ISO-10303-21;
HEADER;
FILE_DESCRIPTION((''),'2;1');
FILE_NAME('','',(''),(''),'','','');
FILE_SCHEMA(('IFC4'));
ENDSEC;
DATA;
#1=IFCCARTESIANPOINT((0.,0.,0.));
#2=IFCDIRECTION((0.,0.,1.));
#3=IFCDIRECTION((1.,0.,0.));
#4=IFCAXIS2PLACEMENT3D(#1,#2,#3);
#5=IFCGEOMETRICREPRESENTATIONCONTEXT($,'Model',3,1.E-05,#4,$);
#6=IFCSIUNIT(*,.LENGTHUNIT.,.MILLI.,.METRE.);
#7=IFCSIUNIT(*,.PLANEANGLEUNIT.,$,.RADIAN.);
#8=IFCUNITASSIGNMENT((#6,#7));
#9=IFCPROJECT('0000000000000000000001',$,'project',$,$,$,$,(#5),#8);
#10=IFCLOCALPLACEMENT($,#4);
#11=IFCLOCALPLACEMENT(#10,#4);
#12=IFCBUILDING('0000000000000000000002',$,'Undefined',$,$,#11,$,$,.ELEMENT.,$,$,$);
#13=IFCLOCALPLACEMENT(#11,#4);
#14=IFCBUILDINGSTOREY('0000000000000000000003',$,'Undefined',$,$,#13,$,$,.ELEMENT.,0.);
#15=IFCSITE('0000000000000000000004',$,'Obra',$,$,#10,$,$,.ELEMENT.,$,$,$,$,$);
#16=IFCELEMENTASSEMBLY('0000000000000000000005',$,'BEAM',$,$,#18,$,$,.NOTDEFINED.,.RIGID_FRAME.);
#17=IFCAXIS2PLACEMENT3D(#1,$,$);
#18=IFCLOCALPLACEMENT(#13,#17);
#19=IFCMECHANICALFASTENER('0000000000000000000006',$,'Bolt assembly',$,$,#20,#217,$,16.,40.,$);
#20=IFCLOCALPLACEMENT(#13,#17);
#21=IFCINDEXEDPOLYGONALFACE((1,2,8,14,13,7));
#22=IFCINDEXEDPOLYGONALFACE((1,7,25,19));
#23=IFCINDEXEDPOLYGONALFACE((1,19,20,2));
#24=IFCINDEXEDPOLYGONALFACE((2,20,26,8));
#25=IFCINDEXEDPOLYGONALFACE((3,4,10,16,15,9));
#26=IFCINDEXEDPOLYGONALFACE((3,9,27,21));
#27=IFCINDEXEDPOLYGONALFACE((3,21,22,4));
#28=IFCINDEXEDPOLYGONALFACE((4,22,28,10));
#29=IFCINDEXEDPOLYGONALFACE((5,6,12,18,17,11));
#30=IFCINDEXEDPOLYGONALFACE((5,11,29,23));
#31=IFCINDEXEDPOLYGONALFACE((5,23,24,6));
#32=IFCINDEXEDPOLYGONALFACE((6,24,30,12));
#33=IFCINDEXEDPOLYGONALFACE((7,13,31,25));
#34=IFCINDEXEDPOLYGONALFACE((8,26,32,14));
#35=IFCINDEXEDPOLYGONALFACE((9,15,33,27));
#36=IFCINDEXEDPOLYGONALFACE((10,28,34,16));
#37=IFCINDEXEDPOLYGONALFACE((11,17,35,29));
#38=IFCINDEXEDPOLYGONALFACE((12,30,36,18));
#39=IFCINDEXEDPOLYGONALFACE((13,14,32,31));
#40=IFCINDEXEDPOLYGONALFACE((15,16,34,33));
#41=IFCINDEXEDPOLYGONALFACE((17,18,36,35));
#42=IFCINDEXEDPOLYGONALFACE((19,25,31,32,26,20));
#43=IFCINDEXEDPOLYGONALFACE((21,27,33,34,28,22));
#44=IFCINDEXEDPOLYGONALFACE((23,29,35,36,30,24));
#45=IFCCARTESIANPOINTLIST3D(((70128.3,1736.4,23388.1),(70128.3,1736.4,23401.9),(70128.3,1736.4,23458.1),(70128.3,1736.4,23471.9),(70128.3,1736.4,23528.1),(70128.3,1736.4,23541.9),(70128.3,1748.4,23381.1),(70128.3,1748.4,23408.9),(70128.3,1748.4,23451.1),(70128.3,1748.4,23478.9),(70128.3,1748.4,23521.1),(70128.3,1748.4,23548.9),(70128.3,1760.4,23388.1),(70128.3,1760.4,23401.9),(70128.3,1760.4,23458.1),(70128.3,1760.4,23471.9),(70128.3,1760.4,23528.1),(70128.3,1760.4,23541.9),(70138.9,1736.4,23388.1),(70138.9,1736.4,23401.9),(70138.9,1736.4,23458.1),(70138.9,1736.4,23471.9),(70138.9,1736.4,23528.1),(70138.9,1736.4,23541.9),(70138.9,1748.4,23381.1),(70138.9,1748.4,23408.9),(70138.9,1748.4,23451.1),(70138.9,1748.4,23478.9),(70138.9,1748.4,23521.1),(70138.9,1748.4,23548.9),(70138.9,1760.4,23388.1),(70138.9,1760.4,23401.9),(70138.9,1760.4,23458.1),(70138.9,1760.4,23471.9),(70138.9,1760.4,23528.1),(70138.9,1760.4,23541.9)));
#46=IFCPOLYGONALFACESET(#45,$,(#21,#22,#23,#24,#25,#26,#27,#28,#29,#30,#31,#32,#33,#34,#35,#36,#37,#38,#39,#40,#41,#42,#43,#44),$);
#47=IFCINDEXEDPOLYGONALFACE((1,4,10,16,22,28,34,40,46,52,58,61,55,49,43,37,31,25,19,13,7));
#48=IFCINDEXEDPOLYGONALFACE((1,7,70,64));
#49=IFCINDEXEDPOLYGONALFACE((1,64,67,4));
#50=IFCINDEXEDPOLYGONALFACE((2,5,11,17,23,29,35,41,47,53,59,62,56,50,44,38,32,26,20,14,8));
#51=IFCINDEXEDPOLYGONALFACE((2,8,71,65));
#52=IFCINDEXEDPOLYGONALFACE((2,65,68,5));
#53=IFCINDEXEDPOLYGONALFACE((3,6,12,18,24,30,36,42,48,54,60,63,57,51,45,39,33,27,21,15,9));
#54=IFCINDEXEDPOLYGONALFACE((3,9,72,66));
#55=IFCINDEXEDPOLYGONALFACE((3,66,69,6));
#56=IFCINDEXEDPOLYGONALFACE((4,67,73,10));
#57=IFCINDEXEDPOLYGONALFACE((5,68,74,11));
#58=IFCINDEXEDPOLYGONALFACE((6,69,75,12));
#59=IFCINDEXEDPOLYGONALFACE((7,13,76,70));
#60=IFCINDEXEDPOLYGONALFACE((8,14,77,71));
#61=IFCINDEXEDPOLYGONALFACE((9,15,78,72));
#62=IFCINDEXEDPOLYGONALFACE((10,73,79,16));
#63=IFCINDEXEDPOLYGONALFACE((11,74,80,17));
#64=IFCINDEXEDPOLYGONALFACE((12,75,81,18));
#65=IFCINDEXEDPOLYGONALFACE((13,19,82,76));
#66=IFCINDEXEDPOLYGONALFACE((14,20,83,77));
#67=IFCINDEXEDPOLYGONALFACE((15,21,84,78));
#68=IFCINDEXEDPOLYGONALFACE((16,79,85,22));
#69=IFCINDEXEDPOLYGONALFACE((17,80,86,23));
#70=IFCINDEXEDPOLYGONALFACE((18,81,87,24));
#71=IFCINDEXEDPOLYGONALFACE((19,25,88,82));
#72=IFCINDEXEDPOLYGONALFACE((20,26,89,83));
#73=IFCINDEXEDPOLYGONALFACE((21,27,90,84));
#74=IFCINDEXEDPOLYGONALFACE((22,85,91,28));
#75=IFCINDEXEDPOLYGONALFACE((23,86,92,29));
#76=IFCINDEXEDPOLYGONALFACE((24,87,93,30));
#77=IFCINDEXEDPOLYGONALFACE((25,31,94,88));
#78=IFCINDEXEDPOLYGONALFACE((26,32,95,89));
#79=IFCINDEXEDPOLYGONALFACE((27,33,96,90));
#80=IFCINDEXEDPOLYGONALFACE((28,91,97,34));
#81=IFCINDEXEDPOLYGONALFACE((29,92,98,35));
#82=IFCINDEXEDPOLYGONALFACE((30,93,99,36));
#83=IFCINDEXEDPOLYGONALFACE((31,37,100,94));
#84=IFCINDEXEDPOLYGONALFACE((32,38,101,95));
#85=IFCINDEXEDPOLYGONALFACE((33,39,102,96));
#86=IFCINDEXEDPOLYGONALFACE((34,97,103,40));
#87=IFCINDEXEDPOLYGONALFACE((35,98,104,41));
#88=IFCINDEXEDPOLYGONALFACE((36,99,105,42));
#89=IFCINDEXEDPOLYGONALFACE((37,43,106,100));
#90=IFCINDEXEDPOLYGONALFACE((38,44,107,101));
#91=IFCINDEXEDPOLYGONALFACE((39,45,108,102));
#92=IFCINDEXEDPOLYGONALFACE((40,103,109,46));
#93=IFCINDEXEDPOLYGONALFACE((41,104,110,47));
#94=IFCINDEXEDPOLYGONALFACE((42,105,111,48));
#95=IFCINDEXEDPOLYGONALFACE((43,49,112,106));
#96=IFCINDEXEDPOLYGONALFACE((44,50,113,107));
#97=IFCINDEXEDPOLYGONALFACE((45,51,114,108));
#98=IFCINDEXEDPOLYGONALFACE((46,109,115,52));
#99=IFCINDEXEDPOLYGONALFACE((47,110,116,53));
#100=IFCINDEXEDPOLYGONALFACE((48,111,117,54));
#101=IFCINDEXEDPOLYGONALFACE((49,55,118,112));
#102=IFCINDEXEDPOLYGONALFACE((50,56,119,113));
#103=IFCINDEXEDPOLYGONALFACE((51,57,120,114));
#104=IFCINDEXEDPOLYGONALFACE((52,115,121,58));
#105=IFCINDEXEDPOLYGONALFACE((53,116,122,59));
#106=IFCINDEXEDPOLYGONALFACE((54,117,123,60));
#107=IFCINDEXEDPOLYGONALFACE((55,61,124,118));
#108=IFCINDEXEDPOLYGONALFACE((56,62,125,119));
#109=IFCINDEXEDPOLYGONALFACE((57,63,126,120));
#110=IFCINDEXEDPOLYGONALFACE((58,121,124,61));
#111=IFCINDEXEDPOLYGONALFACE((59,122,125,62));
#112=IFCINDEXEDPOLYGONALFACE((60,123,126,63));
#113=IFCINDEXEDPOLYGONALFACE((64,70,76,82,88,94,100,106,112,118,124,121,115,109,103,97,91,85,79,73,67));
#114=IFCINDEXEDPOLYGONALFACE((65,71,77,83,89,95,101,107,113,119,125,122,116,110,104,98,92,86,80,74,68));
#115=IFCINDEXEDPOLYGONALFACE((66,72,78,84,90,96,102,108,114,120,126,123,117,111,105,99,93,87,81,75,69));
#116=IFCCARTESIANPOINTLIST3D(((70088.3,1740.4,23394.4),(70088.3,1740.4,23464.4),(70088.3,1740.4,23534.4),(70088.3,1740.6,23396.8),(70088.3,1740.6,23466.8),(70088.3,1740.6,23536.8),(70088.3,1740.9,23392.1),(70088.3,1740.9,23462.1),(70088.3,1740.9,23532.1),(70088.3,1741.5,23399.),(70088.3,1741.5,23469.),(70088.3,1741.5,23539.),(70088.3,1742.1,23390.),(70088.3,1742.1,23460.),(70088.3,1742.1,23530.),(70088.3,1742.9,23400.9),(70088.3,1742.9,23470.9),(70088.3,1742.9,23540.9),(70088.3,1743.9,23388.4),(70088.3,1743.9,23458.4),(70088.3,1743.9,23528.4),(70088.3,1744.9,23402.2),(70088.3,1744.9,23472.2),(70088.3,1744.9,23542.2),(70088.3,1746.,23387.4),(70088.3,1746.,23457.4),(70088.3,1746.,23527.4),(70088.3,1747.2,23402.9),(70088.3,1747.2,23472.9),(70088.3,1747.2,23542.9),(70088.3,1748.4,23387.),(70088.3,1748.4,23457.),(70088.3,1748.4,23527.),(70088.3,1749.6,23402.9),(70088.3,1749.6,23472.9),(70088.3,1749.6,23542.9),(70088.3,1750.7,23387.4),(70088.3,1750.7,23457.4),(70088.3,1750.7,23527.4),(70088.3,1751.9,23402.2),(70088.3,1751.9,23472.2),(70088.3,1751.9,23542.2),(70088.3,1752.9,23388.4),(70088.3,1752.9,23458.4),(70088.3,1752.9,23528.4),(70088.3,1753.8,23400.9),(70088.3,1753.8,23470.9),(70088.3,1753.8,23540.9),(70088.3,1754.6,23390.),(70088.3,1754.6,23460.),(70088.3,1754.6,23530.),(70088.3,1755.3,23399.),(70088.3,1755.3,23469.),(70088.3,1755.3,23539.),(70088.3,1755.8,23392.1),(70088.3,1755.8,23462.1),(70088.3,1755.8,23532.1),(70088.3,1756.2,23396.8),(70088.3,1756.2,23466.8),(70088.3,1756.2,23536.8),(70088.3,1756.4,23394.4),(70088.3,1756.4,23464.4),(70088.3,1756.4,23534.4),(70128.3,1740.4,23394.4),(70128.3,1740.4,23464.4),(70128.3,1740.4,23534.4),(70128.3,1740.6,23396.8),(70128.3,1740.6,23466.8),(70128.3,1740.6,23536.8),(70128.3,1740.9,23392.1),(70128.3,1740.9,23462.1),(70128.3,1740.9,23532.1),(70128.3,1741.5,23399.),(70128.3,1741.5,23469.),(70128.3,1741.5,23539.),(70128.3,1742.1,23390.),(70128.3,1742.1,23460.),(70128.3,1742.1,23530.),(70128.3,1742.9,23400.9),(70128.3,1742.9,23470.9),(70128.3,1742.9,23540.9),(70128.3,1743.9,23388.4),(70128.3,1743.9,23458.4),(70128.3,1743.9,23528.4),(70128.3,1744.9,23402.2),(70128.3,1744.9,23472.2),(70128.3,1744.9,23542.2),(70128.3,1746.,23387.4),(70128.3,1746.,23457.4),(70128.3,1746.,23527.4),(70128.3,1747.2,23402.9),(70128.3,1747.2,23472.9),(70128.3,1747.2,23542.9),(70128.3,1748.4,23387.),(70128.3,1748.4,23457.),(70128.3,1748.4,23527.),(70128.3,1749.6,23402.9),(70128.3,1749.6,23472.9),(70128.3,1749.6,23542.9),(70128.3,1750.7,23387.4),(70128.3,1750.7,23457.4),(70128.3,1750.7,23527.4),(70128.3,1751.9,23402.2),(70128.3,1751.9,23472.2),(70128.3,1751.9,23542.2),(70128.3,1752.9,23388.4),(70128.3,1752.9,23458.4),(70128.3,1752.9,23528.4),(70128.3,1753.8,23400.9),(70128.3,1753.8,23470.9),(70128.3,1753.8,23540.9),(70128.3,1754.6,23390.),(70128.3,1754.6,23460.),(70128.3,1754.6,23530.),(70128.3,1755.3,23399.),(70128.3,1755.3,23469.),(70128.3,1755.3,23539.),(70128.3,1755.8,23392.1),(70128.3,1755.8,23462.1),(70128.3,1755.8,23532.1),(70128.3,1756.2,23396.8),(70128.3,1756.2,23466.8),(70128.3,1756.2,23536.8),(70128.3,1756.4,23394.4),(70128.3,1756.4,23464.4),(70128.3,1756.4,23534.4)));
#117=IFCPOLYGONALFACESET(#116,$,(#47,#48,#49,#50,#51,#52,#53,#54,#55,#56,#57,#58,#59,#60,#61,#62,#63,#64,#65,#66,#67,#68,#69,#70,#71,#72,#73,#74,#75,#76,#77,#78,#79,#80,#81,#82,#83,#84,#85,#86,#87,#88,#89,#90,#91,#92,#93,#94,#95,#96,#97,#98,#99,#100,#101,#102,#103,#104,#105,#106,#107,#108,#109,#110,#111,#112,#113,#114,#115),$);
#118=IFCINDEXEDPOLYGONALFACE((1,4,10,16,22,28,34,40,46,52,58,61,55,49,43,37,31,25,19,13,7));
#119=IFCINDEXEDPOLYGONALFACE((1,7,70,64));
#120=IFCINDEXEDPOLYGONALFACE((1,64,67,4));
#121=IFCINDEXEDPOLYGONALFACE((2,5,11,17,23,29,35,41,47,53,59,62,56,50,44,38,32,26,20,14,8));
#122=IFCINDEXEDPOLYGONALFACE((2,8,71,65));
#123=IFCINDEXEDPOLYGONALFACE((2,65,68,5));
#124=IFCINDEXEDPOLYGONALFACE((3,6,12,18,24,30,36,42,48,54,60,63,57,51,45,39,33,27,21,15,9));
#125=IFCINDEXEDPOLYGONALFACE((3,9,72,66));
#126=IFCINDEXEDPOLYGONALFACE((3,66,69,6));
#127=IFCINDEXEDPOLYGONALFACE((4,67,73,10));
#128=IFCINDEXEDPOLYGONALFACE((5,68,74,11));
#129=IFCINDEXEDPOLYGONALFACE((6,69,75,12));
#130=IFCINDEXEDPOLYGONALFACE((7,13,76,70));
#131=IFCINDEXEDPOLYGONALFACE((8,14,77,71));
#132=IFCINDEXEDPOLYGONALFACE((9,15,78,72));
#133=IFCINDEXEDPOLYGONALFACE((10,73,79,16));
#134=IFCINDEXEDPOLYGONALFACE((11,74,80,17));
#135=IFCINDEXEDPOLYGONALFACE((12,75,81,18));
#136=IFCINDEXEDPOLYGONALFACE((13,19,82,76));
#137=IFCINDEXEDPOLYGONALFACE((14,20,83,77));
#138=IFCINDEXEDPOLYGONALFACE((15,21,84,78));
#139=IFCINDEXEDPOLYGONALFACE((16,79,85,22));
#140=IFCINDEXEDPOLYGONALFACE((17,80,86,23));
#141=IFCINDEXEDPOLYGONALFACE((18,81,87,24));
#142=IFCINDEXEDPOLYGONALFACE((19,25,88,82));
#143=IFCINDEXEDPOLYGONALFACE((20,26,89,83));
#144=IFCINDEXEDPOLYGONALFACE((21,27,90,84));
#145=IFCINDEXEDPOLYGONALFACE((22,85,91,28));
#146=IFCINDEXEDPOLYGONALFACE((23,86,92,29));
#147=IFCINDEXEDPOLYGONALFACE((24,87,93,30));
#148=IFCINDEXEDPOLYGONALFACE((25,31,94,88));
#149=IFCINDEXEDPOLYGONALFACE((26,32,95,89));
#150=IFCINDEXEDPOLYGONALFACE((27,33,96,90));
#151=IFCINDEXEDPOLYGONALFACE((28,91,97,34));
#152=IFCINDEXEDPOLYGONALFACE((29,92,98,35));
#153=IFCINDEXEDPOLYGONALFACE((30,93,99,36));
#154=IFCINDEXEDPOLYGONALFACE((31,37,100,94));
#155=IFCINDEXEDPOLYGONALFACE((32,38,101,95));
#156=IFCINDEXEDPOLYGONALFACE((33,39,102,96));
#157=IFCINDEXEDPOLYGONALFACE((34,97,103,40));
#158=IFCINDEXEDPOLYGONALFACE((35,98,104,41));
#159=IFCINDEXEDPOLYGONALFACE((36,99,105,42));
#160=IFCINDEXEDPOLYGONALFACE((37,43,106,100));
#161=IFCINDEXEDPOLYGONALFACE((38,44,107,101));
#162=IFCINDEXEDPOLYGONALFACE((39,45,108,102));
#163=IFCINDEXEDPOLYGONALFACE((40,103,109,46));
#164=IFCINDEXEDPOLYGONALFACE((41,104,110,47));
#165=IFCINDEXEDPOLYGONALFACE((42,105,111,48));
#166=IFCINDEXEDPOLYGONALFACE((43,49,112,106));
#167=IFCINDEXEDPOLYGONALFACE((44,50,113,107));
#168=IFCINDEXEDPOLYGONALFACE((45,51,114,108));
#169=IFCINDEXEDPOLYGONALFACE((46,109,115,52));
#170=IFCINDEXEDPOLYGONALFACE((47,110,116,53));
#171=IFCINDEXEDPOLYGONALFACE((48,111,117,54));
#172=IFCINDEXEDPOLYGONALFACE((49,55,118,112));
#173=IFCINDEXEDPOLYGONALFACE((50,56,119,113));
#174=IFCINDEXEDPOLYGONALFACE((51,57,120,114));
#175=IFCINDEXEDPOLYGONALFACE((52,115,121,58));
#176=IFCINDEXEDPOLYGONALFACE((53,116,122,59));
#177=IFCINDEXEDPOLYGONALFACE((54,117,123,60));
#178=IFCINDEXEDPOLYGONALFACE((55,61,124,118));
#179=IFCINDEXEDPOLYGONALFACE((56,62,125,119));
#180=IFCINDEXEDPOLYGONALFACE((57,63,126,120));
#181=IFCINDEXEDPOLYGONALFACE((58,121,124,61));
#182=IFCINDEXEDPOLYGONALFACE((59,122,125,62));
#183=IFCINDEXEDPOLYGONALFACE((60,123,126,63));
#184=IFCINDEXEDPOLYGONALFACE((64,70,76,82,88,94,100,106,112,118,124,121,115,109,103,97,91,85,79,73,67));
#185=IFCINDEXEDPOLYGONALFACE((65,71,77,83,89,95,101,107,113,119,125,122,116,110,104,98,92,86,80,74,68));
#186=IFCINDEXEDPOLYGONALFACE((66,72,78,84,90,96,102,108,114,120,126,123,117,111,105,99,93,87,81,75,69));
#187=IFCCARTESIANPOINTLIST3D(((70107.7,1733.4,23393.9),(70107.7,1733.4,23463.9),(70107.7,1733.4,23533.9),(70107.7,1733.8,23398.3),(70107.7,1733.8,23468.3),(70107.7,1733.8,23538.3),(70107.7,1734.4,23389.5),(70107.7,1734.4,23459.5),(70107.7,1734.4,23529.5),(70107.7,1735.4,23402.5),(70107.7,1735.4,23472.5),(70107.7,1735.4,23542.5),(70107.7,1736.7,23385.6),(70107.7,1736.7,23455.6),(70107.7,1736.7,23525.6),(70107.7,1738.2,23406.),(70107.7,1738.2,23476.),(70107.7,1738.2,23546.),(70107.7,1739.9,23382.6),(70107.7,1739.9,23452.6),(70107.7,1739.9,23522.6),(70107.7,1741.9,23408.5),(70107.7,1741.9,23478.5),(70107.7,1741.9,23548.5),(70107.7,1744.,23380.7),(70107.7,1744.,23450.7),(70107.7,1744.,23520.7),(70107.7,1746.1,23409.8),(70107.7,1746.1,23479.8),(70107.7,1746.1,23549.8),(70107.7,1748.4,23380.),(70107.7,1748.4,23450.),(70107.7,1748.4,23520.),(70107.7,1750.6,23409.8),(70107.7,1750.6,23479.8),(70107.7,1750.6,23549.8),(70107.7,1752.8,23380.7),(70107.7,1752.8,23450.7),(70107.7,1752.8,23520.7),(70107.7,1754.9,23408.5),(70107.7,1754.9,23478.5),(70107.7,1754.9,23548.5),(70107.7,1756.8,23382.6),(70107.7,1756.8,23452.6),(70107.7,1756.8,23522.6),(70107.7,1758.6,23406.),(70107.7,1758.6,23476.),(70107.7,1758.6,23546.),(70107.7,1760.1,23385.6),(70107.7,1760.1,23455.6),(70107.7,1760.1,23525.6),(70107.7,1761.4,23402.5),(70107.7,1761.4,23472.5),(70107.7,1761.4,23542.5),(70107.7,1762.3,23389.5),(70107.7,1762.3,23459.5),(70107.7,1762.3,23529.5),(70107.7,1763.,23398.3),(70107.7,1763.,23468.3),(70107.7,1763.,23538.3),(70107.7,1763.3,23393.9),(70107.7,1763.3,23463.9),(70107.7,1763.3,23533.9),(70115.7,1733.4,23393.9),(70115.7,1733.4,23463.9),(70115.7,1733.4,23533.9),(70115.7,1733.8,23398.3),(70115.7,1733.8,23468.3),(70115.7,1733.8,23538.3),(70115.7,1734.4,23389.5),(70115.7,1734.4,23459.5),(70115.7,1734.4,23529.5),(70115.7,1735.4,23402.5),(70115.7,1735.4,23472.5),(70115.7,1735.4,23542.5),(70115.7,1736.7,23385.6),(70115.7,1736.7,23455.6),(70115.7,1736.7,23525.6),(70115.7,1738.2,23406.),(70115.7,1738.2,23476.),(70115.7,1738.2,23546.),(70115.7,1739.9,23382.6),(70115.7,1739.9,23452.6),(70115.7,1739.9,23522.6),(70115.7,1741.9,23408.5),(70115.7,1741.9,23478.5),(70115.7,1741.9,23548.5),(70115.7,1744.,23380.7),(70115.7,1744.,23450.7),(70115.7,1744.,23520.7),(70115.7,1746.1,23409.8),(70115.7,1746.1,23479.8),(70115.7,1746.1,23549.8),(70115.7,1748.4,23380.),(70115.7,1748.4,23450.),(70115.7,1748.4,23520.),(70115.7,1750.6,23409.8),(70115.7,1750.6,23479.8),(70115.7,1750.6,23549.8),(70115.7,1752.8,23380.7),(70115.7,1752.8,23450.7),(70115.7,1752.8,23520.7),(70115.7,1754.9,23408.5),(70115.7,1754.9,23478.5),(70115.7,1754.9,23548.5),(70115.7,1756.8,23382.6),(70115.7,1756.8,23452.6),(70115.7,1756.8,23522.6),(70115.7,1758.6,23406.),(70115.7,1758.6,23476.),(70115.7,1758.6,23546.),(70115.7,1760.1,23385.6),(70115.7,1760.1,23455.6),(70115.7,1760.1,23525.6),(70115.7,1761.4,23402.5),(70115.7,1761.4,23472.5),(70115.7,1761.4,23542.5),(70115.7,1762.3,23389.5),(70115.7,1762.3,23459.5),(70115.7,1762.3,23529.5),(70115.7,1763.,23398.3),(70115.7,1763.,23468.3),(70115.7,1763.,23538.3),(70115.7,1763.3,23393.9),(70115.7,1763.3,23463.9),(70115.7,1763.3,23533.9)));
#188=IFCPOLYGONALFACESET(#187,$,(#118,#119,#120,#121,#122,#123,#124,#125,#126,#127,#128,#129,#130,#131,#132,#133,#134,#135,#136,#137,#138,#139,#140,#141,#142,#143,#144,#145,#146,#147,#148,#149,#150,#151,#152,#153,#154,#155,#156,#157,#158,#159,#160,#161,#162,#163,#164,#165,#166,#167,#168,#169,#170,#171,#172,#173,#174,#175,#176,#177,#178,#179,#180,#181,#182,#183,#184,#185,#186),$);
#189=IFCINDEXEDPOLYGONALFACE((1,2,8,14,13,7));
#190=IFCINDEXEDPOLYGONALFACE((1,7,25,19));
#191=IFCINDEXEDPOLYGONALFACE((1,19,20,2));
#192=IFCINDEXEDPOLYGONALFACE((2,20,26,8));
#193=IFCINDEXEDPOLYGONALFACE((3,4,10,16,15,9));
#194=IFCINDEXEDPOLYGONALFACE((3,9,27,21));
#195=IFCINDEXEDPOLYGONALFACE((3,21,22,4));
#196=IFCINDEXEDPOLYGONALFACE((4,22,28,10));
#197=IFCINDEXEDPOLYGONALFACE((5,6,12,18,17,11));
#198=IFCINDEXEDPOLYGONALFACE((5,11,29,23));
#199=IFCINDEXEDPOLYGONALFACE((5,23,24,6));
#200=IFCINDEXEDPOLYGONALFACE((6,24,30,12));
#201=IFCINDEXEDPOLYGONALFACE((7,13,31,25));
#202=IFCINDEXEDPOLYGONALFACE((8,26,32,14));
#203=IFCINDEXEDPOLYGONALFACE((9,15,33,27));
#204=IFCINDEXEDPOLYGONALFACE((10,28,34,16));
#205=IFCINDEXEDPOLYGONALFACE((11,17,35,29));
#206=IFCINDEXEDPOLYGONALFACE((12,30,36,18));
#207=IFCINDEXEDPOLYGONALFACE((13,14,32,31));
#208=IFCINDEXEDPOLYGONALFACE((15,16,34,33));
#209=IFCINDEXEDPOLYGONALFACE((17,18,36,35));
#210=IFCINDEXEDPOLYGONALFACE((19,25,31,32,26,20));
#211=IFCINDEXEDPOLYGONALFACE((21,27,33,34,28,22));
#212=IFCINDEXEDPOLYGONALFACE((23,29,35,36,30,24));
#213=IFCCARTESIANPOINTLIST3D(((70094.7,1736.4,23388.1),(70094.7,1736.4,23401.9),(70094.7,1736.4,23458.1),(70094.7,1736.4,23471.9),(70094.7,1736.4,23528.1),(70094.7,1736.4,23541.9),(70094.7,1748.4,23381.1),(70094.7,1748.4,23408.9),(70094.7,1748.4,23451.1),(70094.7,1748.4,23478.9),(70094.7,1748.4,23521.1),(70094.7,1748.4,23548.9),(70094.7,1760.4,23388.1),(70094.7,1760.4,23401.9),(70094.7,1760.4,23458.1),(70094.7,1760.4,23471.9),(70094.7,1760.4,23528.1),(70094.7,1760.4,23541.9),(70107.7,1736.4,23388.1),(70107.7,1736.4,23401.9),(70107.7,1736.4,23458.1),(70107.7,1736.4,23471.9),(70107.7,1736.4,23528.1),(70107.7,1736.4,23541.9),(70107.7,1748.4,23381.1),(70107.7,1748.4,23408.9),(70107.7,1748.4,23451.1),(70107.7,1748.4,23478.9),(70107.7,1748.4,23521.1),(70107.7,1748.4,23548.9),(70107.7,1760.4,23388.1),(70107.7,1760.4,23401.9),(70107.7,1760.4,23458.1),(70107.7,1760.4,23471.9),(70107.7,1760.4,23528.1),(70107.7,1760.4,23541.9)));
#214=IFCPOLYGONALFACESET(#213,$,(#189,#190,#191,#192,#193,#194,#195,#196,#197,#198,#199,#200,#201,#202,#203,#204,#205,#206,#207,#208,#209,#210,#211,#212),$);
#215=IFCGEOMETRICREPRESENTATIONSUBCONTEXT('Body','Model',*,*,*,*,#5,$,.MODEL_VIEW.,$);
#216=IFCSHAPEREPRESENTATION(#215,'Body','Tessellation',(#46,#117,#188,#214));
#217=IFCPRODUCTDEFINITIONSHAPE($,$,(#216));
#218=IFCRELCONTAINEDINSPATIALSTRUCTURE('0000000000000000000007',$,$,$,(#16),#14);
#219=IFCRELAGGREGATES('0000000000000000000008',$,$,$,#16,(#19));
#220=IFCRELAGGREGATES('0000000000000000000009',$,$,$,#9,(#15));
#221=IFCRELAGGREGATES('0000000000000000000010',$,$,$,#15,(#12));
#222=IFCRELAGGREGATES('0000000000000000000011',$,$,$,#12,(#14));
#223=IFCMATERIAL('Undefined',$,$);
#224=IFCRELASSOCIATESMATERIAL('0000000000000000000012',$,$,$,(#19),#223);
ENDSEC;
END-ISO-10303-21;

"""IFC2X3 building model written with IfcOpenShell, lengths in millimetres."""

from ifc_helpers import new_model, si_unit, frame, origin_with_axes, origin_2d_with_axis, place, context, subcontext, project, spatial, polyline, circle, outline, extrude, source, transform, mapped, material, element, aggregate, save


model = new_model("IFC2X3")

# Units and contexts
model_context = context("Model", 3, precision=1e-05, world=origin_with_axes())
body_context = subcontext(model_context, "Body", "Model", "MODEL_VIEW")
ifc_project = project(units=[si_unit("LENGTHUNIT", "METRE", prefix="MILLI"), si_unit("PLANEANGLEUNIT", "RADIAN")], contexts=[model_context])

# Site, building, storey
site_placement = place(None, origin_with_axes())
site = spatial("IfcSite", under=ifc_project, at=site_placement, Name="Obra", CompositionType="ELEMENT")
building_placement = place(site_placement, origin_with_axes())
building = spatial("IfcBuilding", under=site, at=building_placement, Name="Undefined", CompositionType="ELEMENT")
storey_placement = place(building_placement, origin_with_axes())
storey = spatial("IfcBuildingStorey", under=building, at=storey_placement, Name="Undefined", CompositionType="ELEMENT", Elevation=0.0)

# Element assembly
assembly_1_placement = place(storey_placement, origin_with_axes())
assembly_1 = element("IfcElementAssembly", 1, at=assembly_1_placement, inside=storey, Name="BEAM", AssemblyPlace="NOTDEFINED", PredefinedType="RIGID_FRAME")

# Shared definitions
ifc_material_1 = material(Name="Undefined")

# Mechanical fastener
shared_shape_1 = source(origin_with_axes(), body_context, "Body", "SweptSolid", [
    extrude(outline(polyline([(13.9, 0.0), (6.9, 12.0), (-6.9, 12.0), (-13.9, 0.0), (-6.9, -12.0), (6.9, -12.0), (13.9, 0.0)])), frame((0.0, -13.9, 0.0), z_axis=(0.0, 1.0, 0.0), x_axis=(1.0, 0.0, 0.0)), (0.0, 0.0, 1.0), 10.6),
    extrude(circle(Radius=8.0, at=origin_2d_with_axis()), frame((0.0, -3.3, 0.0), z_axis=(0.0, 1.0, 0.0), x_axis=(1.0, 0.0, 0.0)), (0.0, 0.0, 1.0), 40.0),
    extrude(circle(Radius=15.0, at=origin_2d_with_axis()), frame((0.0, 9.3, 0.0), z_axis=(0.0, 1.0, 0.0), x_axis=(1.0, 0.0, 0.0)), (0.0, 0.0, 1.0), 8.0),
    extrude(outline(polyline([(13.9, 0.0), (6.9, 12.0), (-6.9, 12.0), (-13.9, 0.0), (-6.9, -12.0), (6.9, -12.0), (13.9, 0.0)])), frame((0.0, 17.3, 0.0), z_axis=(0.0, 1.0, 0.0), x_axis=(1.0, 0.0, 0.0)), (0.0, 0.0, 1.0), 13.0),
])
mechanical_fastener_1_placement = place(assembly_1_placement, frame((70125.0, 1708.4, 23570.0), z_axis=(0.0, 1.0, 0.0), x_axis=(0.0, 0.0, -1.0)))
mechanical_fastener_1 = element("IfcMechanicalFastener", 2, at=mechanical_fastener_1_placement, material=ifc_material_1, Name="Bolt assembly", NominalDiameter=16.0, NominalLength=40.0, context=body_context, shape_type="MappedRepresentation", body=[
    mapped(shared_shape_1, transform((35.0, 0.0, 40.0))),
    mapped(shared_shape_1, transform((105.0, 0.0, 40.0))),
    mapped(shared_shape_1, transform((175.0, 0.0, 40.0))),
])
aggregate(assembly_1, [mechanical_fastener_1])

save(model, "model.ifc")
